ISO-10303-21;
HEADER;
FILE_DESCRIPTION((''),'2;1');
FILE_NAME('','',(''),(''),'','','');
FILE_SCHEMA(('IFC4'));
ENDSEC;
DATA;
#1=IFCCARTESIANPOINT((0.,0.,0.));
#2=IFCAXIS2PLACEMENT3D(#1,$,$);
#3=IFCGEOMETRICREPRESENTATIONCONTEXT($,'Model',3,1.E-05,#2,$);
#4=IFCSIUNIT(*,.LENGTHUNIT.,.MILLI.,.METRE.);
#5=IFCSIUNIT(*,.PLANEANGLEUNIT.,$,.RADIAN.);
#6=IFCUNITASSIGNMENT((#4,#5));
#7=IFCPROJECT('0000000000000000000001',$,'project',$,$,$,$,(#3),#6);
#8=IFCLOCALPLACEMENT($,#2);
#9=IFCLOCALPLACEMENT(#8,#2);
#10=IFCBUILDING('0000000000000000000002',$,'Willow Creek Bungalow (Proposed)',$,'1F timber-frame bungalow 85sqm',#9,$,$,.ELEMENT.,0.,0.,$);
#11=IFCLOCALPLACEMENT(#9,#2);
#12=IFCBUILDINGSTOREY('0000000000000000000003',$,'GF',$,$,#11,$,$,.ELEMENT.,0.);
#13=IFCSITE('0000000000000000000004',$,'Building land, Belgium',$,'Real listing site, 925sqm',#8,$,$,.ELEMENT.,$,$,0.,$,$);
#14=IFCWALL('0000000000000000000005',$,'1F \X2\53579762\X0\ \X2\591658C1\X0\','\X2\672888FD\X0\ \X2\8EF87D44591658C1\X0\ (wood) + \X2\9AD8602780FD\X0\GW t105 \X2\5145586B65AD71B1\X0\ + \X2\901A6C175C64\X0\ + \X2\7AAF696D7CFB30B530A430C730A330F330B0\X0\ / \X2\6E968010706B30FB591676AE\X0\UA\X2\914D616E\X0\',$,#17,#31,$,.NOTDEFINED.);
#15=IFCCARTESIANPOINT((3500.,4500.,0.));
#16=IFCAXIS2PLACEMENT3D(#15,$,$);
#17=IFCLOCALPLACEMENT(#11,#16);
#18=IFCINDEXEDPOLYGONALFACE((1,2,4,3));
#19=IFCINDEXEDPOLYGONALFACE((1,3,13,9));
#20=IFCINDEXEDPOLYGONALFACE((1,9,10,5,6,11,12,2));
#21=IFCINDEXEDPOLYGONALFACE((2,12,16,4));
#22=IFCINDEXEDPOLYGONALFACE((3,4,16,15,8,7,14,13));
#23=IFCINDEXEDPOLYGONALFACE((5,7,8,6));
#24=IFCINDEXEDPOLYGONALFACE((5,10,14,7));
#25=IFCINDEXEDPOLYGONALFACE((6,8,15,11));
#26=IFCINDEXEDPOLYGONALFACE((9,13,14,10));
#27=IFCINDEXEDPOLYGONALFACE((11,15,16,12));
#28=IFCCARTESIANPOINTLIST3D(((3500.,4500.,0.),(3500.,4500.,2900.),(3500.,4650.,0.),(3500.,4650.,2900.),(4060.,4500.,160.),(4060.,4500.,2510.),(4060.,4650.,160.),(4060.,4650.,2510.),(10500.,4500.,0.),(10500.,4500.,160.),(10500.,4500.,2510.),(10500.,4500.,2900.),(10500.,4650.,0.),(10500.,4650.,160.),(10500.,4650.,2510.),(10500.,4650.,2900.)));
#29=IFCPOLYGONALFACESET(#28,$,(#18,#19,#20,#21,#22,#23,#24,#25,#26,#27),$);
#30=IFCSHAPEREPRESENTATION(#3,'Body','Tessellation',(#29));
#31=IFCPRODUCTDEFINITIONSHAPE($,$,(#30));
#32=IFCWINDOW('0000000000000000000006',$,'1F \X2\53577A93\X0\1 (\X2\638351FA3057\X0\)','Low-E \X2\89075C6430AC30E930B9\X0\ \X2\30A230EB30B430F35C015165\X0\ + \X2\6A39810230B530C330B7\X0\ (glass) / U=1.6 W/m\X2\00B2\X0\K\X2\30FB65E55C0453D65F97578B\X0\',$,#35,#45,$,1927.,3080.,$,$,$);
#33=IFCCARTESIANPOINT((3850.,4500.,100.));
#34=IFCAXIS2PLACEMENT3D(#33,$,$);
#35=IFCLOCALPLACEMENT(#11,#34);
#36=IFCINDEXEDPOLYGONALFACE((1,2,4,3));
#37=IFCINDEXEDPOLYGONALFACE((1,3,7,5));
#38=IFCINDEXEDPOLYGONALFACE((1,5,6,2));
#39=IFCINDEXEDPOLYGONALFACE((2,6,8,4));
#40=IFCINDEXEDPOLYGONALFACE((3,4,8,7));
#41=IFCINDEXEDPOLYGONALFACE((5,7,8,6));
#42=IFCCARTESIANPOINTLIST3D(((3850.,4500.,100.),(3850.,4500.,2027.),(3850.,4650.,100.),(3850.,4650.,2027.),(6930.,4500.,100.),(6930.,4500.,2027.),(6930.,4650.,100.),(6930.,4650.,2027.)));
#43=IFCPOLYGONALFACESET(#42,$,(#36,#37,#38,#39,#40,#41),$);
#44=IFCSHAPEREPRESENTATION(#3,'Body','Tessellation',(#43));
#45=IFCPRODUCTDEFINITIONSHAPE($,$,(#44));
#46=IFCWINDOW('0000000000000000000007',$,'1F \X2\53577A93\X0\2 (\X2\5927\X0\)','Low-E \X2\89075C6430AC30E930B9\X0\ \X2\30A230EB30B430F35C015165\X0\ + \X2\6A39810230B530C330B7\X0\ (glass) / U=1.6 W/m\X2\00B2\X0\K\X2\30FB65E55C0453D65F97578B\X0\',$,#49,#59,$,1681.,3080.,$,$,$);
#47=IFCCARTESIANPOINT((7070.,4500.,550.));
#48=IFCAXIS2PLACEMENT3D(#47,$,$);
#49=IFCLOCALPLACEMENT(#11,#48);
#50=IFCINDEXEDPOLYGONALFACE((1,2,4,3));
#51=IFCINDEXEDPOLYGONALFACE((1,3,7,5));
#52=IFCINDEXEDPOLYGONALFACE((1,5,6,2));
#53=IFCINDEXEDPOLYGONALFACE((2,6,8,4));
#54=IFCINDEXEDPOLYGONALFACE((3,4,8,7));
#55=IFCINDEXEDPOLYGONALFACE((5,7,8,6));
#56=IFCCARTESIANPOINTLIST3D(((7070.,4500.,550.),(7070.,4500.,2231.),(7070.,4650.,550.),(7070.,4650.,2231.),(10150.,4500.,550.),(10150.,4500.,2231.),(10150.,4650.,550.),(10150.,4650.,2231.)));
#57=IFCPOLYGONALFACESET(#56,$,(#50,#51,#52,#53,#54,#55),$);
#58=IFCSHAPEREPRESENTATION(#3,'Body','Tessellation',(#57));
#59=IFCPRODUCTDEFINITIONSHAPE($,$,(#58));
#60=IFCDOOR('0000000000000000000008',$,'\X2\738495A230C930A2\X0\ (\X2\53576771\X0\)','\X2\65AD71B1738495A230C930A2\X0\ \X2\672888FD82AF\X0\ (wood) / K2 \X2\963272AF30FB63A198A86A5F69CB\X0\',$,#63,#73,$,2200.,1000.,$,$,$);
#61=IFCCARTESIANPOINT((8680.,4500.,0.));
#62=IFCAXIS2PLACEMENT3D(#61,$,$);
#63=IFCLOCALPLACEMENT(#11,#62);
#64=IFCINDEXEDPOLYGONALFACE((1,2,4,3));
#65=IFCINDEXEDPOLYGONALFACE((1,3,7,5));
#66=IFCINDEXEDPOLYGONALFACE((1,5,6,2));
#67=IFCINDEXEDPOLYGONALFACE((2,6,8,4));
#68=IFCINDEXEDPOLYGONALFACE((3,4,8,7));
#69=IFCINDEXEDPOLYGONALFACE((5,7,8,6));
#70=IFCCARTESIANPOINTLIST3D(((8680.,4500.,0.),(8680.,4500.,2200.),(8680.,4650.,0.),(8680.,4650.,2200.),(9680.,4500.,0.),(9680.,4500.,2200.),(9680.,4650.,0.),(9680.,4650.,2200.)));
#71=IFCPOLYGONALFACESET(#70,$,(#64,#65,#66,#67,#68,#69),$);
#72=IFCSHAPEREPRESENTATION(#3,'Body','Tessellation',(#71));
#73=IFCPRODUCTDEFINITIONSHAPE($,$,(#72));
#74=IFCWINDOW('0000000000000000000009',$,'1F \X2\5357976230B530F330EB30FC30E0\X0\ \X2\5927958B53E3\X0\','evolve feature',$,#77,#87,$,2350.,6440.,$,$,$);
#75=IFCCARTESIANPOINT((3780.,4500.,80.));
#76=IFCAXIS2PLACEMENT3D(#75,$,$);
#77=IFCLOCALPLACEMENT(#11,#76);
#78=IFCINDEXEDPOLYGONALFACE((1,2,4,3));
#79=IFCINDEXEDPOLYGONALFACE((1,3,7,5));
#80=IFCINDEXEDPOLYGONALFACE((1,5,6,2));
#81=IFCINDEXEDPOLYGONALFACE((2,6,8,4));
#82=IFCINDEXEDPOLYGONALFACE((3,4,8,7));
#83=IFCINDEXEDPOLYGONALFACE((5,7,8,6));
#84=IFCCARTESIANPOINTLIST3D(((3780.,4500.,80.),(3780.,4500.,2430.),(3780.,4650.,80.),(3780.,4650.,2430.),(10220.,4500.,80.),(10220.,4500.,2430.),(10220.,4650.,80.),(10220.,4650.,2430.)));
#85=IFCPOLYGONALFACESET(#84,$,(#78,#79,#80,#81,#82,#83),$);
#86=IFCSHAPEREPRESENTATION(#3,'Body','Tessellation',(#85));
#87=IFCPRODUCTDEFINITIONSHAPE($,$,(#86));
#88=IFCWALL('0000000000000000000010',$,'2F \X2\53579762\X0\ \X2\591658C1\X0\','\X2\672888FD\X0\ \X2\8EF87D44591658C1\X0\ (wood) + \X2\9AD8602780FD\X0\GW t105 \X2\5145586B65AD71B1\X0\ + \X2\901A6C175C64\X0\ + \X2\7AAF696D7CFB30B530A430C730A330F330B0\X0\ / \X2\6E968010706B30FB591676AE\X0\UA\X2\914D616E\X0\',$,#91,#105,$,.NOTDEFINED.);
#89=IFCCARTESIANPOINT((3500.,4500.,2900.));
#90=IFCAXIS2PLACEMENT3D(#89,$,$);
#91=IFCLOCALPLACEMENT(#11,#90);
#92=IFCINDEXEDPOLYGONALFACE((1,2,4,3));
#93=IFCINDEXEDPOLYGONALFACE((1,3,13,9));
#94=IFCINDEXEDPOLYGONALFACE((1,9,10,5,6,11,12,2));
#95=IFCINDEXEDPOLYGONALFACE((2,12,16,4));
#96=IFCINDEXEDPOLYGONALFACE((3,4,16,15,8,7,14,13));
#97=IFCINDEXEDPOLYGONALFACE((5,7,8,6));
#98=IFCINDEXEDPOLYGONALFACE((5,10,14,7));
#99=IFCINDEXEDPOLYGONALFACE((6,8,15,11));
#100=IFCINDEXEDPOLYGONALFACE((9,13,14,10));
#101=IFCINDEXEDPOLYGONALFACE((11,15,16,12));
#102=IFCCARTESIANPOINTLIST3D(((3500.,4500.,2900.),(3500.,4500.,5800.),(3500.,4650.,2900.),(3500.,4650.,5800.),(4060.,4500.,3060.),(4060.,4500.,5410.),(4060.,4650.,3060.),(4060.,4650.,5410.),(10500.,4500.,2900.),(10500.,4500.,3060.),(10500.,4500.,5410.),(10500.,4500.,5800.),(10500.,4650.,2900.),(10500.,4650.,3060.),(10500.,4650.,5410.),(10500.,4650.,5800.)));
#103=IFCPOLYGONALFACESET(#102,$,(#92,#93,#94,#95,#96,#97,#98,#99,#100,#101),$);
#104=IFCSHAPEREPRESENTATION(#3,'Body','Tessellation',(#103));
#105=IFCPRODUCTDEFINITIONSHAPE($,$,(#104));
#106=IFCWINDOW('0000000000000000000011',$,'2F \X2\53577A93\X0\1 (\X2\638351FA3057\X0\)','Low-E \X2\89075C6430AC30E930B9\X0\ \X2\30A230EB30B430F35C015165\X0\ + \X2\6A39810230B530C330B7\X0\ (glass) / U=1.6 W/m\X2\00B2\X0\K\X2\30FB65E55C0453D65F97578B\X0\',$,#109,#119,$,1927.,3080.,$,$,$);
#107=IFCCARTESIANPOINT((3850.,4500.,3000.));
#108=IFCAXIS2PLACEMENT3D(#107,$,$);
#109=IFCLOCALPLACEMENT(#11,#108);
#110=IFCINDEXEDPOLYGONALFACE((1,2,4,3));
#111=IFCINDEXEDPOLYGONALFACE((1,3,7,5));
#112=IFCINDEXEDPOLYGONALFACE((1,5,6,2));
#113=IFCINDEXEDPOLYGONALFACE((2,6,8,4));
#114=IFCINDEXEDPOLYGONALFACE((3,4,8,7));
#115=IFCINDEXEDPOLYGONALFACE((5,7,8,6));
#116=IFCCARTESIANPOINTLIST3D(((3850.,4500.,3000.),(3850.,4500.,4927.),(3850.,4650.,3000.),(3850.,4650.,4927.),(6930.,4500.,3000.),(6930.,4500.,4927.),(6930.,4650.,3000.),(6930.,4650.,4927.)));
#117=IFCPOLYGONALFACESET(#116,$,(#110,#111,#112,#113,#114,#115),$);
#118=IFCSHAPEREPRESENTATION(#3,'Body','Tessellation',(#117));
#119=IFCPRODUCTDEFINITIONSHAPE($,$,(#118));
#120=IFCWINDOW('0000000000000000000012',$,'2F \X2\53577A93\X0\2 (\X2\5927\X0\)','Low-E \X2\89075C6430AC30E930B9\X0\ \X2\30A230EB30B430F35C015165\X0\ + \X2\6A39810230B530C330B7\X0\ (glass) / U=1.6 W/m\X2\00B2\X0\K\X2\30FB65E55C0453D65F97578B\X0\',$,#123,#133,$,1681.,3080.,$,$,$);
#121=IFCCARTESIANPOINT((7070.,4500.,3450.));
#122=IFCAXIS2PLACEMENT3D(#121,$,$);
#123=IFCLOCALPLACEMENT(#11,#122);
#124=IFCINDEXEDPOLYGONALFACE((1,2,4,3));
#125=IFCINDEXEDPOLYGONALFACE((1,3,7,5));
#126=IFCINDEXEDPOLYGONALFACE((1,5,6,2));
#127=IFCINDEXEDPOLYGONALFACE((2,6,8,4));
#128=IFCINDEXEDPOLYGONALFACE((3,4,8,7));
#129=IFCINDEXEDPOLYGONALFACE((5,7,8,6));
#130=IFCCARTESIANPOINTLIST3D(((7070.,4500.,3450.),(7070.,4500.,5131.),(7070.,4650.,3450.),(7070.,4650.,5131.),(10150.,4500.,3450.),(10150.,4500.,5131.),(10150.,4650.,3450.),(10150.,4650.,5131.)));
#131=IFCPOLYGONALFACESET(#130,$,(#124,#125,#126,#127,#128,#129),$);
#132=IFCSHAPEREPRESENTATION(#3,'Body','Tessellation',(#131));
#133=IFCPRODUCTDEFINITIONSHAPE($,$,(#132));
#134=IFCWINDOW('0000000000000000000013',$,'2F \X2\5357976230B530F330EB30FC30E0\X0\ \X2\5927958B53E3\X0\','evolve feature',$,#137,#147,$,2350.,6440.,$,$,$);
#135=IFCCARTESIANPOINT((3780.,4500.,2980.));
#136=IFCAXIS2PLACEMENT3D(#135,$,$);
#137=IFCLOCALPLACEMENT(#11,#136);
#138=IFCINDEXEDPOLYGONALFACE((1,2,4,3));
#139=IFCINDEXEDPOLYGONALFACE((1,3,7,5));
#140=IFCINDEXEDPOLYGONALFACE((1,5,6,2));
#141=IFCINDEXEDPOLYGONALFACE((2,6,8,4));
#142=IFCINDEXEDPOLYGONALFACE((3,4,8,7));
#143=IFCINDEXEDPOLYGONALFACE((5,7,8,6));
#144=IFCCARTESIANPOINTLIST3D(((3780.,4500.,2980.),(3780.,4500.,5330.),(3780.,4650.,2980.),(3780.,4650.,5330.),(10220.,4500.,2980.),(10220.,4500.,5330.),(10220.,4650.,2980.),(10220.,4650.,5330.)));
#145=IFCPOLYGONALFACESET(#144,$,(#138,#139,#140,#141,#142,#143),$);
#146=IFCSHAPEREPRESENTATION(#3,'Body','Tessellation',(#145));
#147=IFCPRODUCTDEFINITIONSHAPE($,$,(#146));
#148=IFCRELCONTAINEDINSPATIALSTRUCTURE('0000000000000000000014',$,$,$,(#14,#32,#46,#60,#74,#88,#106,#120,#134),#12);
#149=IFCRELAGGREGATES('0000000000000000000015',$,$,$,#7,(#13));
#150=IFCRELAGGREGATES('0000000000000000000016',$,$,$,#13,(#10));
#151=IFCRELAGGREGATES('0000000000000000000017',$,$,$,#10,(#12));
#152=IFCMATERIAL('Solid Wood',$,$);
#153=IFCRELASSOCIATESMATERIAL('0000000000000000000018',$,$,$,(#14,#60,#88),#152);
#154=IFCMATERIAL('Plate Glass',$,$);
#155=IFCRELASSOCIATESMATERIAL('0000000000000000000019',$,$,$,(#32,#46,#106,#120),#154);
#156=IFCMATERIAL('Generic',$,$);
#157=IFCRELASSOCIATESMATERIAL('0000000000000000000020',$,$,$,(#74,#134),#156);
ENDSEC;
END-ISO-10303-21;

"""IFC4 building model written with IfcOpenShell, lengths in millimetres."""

from ifc_helpers import new_model, si_unit, frame, frame_2d, origin, place, context, project, spatial, rectangle, extrude, material, element, fill, save


model = new_model("IFC4")

# Units and contexts
model_context = context("Model", 3, precision=1e-05, world=origin())
ifc_project = project(units=[si_unit("LENGTHUNIT", "METRE", prefix="MILLI"), si_unit("PLANEANGLEUNIT", "RADIAN")], contexts=[model_context])

# Site, building, storey
site_placement = place(None, origin())
site = spatial("IfcSite", under=ifc_project, at=site_placement, Name="Building land, Belgium", ObjectType="Real listing site, 925sqm", CompositionType="ELEMENT", RefElevation=0.0)
building_placement = place(site_placement, origin())
building = spatial("IfcBuilding", under=site, at=building_placement, Name="Willow Creek Bungalow (Proposed)", ObjectType="1F timber-frame bungalow 85sqm", CompositionType="ELEMENT", ElevationOfRefHeight=0.0, ElevationOfTerrain=0.0)
storey_placement = place(building_placement, origin())
storey = spatial("IfcBuildingStorey", under=building, at=storey_placement, Name="GF", CompositionType="ELEMENT", Elevation=0.0)

# Shared definitions
ifc_material_1 = material(Name="Solid Wood")
ifc_material_2 = material(Name="Generic")

# Wall, openings, windows, door
wall_1_placement = place(storey_placement, frame((3500.0, 4500.0, 0.0)))
wall_1 = element("IfcWall", 1, at=wall_1_placement, inside=storey, material=ifc_material_1, Name="1F 南面 外壁", Description="木製 軸組外壁 (wood) + 高性能GW t105 充填断熱 + 通気層 + 窯業系サイディング / 準耐火・外皮UA配慮", PredefinedType="NOTDEFINED", context=model_context, shape_type="SweptSolid", body=[
    extrude(rectangle(XDim=7000.0, YDim=150.0, at=frame_2d((3500.0, 75.0))), frame((3500.0, 4500.0, 0.0)), (0.0, 0.0, 1.0), 2900.0),
])
opening_1_placement = place(storey_placement, frame((3850.0, 4500.0, 100.0)))
opening_1 = element("IfcOpeningElement", 2, at=opening_1_placement, cuts=wall_1, PredefinedType="NOTDEFINED", context=model_context, shape_type="SweptSolid", body=[
    extrude(rectangle(XDim=3080.0, YDim=150.0, at=frame_2d((1540.0, 75.0))), frame((3850.0, 4500.0, 100.0)), (0.0, 0.0, 1.0), 1927.0),
])
opening_2_placement = place(storey_placement, frame((7070.0, 4500.0, 550.0)))
opening_2 = element("IfcOpeningElement", 3, at=opening_2_placement, cuts=wall_1, PredefinedType="NOTDEFINED", context=model_context, shape_type="SweptSolid", body=[
    extrude(rectangle(XDim=3080.0, YDim=150.0, at=frame_2d((1540.0, 75.0))), frame((7070.0, 4500.0, 550.0)), (0.0, 0.0, 1.0), 1681.0),
])
opening_3_placement = place(storey_placement, frame((8680.0, 4500.0, 0.0)))
opening_3 = element("IfcOpeningElement", 4, at=opening_3_placement, cuts=wall_1, PredefinedType="NOTDEFINED", context=model_context, shape_type="SweptSolid", body=[
    extrude(rectangle(XDim=1000.0, YDim=150.0, at=frame_2d((500.0, 75.0))), frame((8680.0, 4500.0, 0.0)), (0.0, 0.0, 1.0), 2200.0),
])
opening_4_placement = place(storey_placement, frame((3780.0, 4500.0, 80.0)))
opening_4 = element("IfcOpeningElement", 5, at=opening_4_placement, cuts=wall_1, PredefinedType="NOTDEFINED", context=model_context, shape_type="SweptSolid", body=[
    extrude(rectangle(XDim=6440.0, YDim=150.0, at=frame_2d((3220.0, 75.0))), frame((3780.0, 4500.0, 80.0)), (0.0, 0.0, 1.0), 2350.0),
])
ifc_material_3 = material(Name="Plate Glass")
window_1_placement = place(storey_placement, frame((3850.0, 4500.0, 100.0)))
window_1 = element("IfcWindow", 6, at=window_1_placement, inside=storey, material=ifc_material_3, Name="1F 南窓1 (掃出し)", Description="Low-E 複層ガラス アルゴン封入 + 樹脂サッシ (glass) / U=1.6 W/m²K・日射取得型", OverallHeight=1927.0, OverallWidth=3080.0, context=model_context, shape_type="SweptSolid", body=[
    extrude(rectangle(XDim=3080.0, YDim=150.0, at=frame_2d((1540.0, 75.0))), frame((3850.0, 4500.0, 100.0)), (0.0, 0.0, 1.0), 1927.0),
])
fill(opening_1, window_1)
window_2_placement = place(storey_placement, frame((7070.0, 4500.0, 550.0)))
window_2 = element("IfcWindow", 7, at=window_2_placement, inside=storey, material=ifc_material_3, Name="1F 南窓2 (大)", Description="Low-E 複層ガラス アルゴン封入 + 樹脂サッシ (glass) / U=1.6 W/m²K・日射取得型", OverallHeight=1681.0, OverallWidth=3080.0, context=model_context, shape_type="SweptSolid", body=[
    extrude(rectangle(XDim=3080.0, YDim=150.0, at=frame_2d((1540.0, 75.0))), frame((7070.0, 4500.0, 550.0)), (0.0, 0.0, 1.0), 1681.0),
])
fill(opening_2, window_2)
door_placement = place(storey_placement, frame((8680.0, 4500.0, 0.0)))
door = element("IfcDoor", 8, at=door_placement, inside=storey, material=ifc_material_1, Name="玄関ドア (南東)", Description="断熱玄関ドア 木製芯 (wood) / K2 防犯・採風機構", OverallHeight=2200.0, OverallWidth=1000.0, context=model_context, shape_type="SweptSolid", body=[
    extrude(rectangle(XDim=1000.0, YDim=150.0, at=frame_2d((500.0, 75.0))), frame((8680.0, 4500.0, 0.0)), (0.0, 0.0, 1.0), 2200.0),
])
fill(opening_3, door)
window_3_placement = place(storey_placement, frame((3780.0, 4500.0, 80.0)))
window_3 = element("IfcWindow", 9, at=window_3_placement, inside=storey, material=ifc_material_2, Name="1F 南面サンルーム 大開口", Description="evolve feature", OverallHeight=2350.0, OverallWidth=6440.0, context=model_context, shape_type="SweptSolid", body=[
    extrude(rectangle(XDim=6440.0, YDim=150.0, at=frame_2d((3220.0, 75.0))), frame((3780.0, 4500.0, 80.0)), (0.0, 0.0, 1.0), 2350.0),
])
fill(opening_4, window_3)

# Wall, openings, windows
wall_2_placement = place(storey_placement, frame((3500.0, 4500.0, 2900.0)))
wall_2 = element("IfcWall", 10, at=wall_2_placement, inside=storey, material=ifc_material_1, Name="2F 南面 外壁", Description="木製 軸組外壁 (wood) + 高性能GW t105 充填断熱 + 通気層 + 窯業系サイディング / 準耐火・外皮UA配慮", PredefinedType="NOTDEFINED", context=model_context, shape_type="SweptSolid", body=[
    extrude(rectangle(XDim=7000.0, YDim=150.0, at=frame_2d((3500.0, 75.0))), frame((3500.0, 4500.0, 2900.0)), (0.0, 0.0, 1.0), 2900.0),
])
opening_5_placement = place(storey_placement, frame((3850.0, 4500.0, 3000.0)))
opening_5 = element("IfcOpeningElement", 11, at=opening_5_placement, cuts=wall_2, PredefinedType="NOTDEFINED", context=model_context, shape_type="SweptSolid", body=[
    extrude(rectangle(XDim=3080.0, YDim=150.0, at=frame_2d((1540.0, 75.0))), frame((3850.0, 4500.0, 3000.0)), (0.0, 0.0, 1.0), 1927.0),
])
opening_6_placement = place(storey_placement, frame((7070.0, 4500.0, 3450.0)))
opening_6 = element("IfcOpeningElement", 12, at=opening_6_placement, cuts=wall_2, PredefinedType="NOTDEFINED", context=model_context, shape_type="SweptSolid", body=[
    extrude(rectangle(XDim=3080.0, YDim=150.0, at=frame_2d((1540.0, 75.0))), frame((7070.0, 4500.0, 3450.0)), (0.0, 0.0, 1.0), 1681.0),
])
opening_7_placement = place(storey_placement, frame((3780.0, 4500.0, 2980.0)))
opening_7 = element("IfcOpeningElement", 13, at=opening_7_placement, cuts=wall_2, PredefinedType="NOTDEFINED", context=model_context, shape_type="SweptSolid", body=[
    extrude(rectangle(XDim=6440.0, YDim=150.0, at=frame_2d((3220.0, 75.0))), frame((3780.0, 4500.0, 2980.0)), (0.0, 0.0, 1.0), 2350.0),
])
window_4_placement = place(storey_placement, frame((3850.0, 4500.0, 3000.0)))
window_4 = element("IfcWindow", 14, at=window_4_placement, inside=storey, material=ifc_material_3, Name="2F 南窓1 (掃出し)", Description="Low-E 複層ガラス アルゴン封入 + 樹脂サッシ (glass) / U=1.6 W/m²K・日射取得型", OverallHeight=1927.0, OverallWidth=3080.0, context=model_context, shape_type="SweptSolid", body=[
    extrude(rectangle(XDim=3080.0, YDim=150.0, at=frame_2d((1540.0, 75.0))), frame((3850.0, 4500.0, 3000.0)), (0.0, 0.0, 1.0), 1927.0),
])
fill(opening_5, window_4)
window_5_placement = place(storey_placement, frame((7070.0, 4500.0, 3450.0)))
window_5 = element("IfcWindow", 15, at=window_5_placement, inside=storey, material=ifc_material_3, Name="2F 南窓2 (大)", Description="Low-E 複層ガラス アルゴン封入 + 樹脂サッシ (glass) / U=1.6 W/m²K・日射取得型", OverallHeight=1681.0, OverallWidth=3080.0, context=model_context, shape_type="SweptSolid", body=[
    extrude(rectangle(XDim=3080.0, YDim=150.0, at=frame_2d((1540.0, 75.0))), frame((7070.0, 4500.0, 3450.0)), (0.0, 0.0, 1.0), 1681.0),
])
fill(opening_6, window_5)
window_6_placement = place(storey_placement, frame((3780.0, 4500.0, 2980.0)))
window_6 = element("IfcWindow", 16, at=window_6_placement, inside=storey, material=ifc_material_2, Name="2F 南面サンルーム 大開口", Description="evolve feature", OverallHeight=2350.0, OverallWidth=6440.0, context=model_context, shape_type="SweptSolid", body=[
    extrude(rectangle(XDim=6440.0, YDim=150.0, at=frame_2d((3220.0, 75.0))), frame((3780.0, 4500.0, 2980.0)), (0.0, 0.0, 1.0), 2350.0),
])
fill(opening_7, window_6)

save(model, "model.ifc")
